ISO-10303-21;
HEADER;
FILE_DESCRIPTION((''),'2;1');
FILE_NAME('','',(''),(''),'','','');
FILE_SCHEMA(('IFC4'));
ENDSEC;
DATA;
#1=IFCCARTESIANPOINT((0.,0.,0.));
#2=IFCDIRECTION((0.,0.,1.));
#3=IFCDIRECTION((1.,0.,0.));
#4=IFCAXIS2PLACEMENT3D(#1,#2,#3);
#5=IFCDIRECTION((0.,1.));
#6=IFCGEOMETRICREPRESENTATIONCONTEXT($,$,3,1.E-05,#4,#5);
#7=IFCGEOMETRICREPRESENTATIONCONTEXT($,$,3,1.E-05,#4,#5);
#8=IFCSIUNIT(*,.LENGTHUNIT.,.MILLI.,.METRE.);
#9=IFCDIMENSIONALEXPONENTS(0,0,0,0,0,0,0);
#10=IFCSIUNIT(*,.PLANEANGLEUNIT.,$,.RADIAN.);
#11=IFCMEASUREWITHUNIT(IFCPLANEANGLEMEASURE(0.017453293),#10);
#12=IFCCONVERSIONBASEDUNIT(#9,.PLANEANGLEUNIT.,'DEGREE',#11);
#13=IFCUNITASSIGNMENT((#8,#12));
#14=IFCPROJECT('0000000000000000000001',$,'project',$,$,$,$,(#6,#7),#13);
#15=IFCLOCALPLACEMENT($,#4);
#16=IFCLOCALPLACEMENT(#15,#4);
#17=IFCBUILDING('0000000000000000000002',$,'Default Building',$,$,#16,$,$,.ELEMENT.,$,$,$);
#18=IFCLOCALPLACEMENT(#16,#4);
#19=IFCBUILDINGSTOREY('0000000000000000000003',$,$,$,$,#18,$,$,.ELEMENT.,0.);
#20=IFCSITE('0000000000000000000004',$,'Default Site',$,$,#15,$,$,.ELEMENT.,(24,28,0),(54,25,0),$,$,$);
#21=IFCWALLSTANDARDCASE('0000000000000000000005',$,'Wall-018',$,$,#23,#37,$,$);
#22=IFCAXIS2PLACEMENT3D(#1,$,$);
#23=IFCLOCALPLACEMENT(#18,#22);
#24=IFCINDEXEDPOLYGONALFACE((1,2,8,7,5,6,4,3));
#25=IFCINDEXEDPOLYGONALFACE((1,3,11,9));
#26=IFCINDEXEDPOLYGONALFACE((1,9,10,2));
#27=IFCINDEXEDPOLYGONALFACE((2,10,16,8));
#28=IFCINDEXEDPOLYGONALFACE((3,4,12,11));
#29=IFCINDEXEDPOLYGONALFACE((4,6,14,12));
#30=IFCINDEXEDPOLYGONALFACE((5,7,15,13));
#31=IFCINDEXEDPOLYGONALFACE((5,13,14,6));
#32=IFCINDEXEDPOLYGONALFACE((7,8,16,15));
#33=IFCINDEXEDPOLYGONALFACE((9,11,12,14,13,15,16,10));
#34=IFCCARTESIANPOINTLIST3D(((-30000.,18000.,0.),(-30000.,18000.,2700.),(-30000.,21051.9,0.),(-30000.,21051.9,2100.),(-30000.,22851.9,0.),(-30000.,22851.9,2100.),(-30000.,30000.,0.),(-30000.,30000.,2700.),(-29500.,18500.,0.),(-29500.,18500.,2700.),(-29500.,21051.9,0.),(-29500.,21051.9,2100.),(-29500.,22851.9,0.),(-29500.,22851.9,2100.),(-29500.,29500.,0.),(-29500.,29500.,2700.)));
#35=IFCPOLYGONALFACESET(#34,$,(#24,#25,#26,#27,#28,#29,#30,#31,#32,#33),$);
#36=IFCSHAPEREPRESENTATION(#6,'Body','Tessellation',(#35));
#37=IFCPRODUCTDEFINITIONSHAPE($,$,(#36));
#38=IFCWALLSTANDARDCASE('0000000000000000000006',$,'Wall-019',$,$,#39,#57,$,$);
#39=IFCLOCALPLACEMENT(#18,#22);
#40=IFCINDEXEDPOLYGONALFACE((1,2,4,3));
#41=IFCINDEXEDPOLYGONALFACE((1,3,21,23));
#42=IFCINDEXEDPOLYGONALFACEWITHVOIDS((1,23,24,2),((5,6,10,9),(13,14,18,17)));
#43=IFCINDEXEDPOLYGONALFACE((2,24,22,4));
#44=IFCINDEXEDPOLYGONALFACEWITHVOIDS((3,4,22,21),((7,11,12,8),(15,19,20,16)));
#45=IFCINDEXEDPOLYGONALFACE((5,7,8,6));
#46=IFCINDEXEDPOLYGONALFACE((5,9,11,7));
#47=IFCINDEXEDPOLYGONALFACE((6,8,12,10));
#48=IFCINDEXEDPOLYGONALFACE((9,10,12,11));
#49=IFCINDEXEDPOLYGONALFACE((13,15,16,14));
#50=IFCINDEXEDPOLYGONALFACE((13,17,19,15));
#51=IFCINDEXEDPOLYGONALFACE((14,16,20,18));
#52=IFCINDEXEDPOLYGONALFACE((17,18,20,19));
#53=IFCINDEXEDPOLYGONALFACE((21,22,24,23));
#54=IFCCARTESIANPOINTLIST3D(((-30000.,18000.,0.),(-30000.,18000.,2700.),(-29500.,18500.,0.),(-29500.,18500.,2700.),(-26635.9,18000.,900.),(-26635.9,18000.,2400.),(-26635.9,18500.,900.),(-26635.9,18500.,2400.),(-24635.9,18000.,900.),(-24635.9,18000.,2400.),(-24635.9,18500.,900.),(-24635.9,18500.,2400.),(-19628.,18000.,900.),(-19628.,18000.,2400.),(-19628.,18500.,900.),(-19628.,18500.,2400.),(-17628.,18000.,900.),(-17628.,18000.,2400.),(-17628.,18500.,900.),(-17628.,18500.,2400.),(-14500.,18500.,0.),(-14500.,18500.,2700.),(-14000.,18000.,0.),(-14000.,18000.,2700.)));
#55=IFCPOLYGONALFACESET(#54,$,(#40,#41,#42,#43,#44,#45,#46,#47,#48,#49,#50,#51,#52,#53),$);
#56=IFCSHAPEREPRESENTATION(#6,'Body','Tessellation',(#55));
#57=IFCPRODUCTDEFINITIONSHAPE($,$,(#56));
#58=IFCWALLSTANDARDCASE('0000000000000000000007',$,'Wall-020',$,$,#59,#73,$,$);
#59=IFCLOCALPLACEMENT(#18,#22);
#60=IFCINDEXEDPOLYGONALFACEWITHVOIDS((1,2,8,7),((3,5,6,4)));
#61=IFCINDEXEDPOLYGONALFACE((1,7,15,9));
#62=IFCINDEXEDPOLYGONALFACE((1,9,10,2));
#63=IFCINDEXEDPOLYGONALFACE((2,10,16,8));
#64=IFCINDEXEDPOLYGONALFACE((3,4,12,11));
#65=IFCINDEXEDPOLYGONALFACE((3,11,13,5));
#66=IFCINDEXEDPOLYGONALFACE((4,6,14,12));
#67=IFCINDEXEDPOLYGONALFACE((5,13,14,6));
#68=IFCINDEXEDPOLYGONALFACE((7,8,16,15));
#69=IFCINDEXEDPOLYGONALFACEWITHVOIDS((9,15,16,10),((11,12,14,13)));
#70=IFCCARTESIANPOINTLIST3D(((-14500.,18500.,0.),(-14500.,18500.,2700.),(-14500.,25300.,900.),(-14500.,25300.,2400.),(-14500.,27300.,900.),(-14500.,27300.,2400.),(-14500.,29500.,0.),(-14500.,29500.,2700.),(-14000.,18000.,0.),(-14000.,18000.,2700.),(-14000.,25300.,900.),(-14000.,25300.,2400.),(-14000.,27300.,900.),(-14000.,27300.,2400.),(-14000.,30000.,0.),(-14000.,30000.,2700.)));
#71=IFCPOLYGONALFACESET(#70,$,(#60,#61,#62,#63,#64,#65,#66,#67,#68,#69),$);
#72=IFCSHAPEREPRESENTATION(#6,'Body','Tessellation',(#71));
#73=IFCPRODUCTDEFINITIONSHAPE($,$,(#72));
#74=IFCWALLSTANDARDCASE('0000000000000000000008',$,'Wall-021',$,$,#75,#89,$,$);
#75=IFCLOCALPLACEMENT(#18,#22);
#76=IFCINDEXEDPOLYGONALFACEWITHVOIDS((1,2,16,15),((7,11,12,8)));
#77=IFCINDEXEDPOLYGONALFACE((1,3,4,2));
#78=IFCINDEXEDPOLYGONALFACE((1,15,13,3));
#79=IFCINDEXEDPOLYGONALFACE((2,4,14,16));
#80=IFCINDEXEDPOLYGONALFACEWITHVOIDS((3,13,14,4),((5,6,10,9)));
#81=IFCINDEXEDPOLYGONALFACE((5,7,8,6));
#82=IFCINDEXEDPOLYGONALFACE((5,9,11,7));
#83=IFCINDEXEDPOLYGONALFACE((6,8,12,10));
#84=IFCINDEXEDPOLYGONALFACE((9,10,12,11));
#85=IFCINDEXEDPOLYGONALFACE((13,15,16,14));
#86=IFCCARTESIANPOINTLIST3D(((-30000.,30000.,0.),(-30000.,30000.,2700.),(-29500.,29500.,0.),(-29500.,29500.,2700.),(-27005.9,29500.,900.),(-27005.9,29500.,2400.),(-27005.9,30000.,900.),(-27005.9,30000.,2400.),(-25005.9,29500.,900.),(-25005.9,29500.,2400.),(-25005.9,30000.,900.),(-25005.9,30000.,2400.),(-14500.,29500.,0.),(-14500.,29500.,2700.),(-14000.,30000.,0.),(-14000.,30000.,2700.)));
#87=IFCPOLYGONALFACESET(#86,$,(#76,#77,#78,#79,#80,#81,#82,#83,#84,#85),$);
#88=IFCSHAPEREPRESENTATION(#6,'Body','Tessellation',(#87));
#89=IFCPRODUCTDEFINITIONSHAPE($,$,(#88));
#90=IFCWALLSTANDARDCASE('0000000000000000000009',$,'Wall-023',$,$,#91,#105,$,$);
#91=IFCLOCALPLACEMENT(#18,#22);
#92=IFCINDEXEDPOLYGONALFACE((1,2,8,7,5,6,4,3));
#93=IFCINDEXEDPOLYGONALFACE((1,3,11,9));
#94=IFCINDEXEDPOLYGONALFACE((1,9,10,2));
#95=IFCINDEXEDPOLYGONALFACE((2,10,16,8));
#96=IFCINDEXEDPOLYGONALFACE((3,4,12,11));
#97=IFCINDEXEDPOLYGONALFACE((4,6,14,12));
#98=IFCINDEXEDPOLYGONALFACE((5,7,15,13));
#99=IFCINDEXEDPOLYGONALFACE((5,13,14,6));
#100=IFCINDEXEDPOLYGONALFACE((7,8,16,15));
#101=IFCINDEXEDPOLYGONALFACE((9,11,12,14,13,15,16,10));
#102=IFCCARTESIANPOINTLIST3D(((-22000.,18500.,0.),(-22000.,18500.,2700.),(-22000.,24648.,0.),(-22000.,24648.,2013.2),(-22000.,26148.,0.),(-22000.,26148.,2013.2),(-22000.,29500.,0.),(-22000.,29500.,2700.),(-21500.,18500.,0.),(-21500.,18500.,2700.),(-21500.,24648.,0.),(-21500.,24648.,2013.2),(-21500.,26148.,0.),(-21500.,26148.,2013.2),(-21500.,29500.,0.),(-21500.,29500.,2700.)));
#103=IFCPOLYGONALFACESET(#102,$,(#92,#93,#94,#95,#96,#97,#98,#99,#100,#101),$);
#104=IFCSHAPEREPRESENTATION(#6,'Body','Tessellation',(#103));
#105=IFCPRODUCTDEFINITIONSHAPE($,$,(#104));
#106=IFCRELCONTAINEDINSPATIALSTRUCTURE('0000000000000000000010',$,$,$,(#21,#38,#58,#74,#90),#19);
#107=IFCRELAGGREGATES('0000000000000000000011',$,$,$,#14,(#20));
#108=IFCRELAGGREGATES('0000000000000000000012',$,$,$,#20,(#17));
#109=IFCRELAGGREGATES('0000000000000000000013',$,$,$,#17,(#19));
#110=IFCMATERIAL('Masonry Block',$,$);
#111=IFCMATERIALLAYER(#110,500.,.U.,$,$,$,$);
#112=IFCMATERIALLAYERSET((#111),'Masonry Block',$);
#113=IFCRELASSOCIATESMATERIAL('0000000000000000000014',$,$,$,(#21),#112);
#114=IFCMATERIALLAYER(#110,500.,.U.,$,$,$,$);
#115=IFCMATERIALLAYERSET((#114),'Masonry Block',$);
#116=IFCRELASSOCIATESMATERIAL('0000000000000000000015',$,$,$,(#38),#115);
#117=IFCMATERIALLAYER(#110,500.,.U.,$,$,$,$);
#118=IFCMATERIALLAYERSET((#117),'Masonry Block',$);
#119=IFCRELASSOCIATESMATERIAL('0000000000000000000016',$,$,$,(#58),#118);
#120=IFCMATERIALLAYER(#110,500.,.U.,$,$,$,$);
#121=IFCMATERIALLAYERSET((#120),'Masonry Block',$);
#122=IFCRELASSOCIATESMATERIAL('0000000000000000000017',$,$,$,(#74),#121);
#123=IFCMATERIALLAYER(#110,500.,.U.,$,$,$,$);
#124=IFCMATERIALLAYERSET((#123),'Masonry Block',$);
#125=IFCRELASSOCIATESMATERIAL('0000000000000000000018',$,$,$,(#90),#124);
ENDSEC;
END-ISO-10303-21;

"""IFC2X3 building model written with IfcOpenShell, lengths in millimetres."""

from ifc_helpers import new_model, entity, si_unit, converted_unit, direction, frame, frame_2d, origin_with_axes, place, context, project, spatial, polyline, rectangle, outline, extrude, material, layer, layer_set, layer_usage, element, save


model = new_model("IFC2X3")

# Units and contexts
context_of_model_1 = context(None, 3, precision=1e-05, world=origin_with_axes(), true_north=direction((0.0, 1.0)))
context_of_model_2 = context(None, 3, precision=1e-05, world=origin_with_axes(), true_north=direction((0.0, 1.0)))
ifc_project = project(units=[si_unit("LENGTHUNIT", "METRE", prefix="MILLI"), converted_unit("PLANEANGLEUNIT", "DEGREE", entity("IfcPlaneAngleMeasure", 0.017453293), si_unit("PLANEANGLEUNIT", "RADIAN"), dimensions=[0, 0, 0, 0, 0, 0, 0])], contexts=[context_of_model_1, context_of_model_2])

# Site, building, storey
site_placement = place(None, origin_with_axes())
site = spatial("IfcSite", under=ifc_project, at=site_placement, Name="Default Site", CompositionType="ELEMENT", RefLatitude=(24, 28, 0), RefLongitude=(54, 25, 0))
building_placement = place(site_placement, origin_with_axes())
building = spatial("IfcBuilding", under=site, at=building_placement, Name="Default Building", CompositionType="ELEMENT")
storey_placement = place(building_placement, origin_with_axes())
storey = spatial("IfcBuildingStorey", under=building, at=storey_placement, CompositionType="ELEMENT", Elevation=0.0)

# Wall, opening
ifc_material = material(Name="Masonry Block")
ifc_layer_1 = layer(ifc_material, 500.0, ventilated="UNKNOWN")
ifc_layer_set_1 = layer_set([ifc_layer_1], Name="Masonry Block")
ifc_layer_usage_1 = layer_usage(ifc_layer_set_1, "AXIS2", "POSITIVE", 0.0)
wall_1_placement = place(storey_placement, frame((-30000.0, 30000.0, 0.0), z_axis=(0.0, 0.0, 1.0), x_axis=(0.0, -1.0, 0.0)))
wall_1 = element("IfcWallStandardCase", 1, at=wall_1_placement, inside=storey, material=ifc_layer_usage_1, Name="Wall-018", context=context_of_model_1, shape_type="SweptSolid", body=[
    extrude(outline(polyline([(0.0, 0.0), (12000.0, 0.0), (11500.0, 500.0), (500.0, 500.0), (0.0, 0.0)])), origin_with_axes(), (0.0, 0.0, 1.0), 2700.0),
])
opening_1_placement = place(wall_1_placement, frame((8048.1, 0.0, 0.0), z_axis=(0.0, 0.0, 1.0), x_axis=(1.0, 0.0, 0.0)))
element("IfcOpeningElement", 2, at=opening_1_placement, cuts=wall_1, context=context_of_model_1, shape_type="SweptSolid", body=[
    extrude(rectangle(XDim=2100.0, YDim=1800.0, at=frame_2d((0.0, 1050.0), x_axis=(0.0, -1.0))), frame((0.0, 0.0, 0.0), z_axis=(0.0, 1.0, 0.0), x_axis=(-1.0, 0.0, 0.0)), (0.0, 0.0, 1.0), 500.0),
])

# Wall, openings
ifc_layer_2 = layer(ifc_material, 500.0, ventilated="UNKNOWN")
ifc_layer_set_2 = layer_set([ifc_layer_2], Name="Masonry Block")
ifc_layer_usage_2 = layer_usage(ifc_layer_set_2, "AXIS2", "POSITIVE", 0.0)
wall_2_placement = place(storey_placement, frame((-30000.0, 18000.0, 0.0), z_axis=(0.0, 0.0, 1.0), x_axis=(1.0, 0.0, 0.0)))
wall_2 = element("IfcWallStandardCase", 3, at=wall_2_placement, inside=storey, material=ifc_layer_usage_2, Name="Wall-019", context=context_of_model_1, shape_type="SweptSolid", body=[
    extrude(outline(polyline([(0.0, 0.0), (16000.0, 0.0), (15500.0, 500.0), (500.0, 500.0), (0.0, 0.0)])), origin_with_axes(), (0.0, 0.0, 1.0), 2700.0),
])
opening_2_placement = place(wall_2_placement, frame((11372.0, 0.0, 900.0), z_axis=(0.0, 0.0, 1.0), x_axis=(1.0, 0.0, 0.0)))
element("IfcOpeningElement", 4, at=opening_2_placement, cuts=wall_2, context=context_of_model_1, shape_type="SweptSolid", body=[
    extrude(rectangle(XDim=1500.0, YDim=2000.0, at=frame_2d((0.0, 750.0), x_axis=(0.0, 1.0))), frame((0.0, 0.0, 0.0), z_axis=(0.0, 1.0, 0.0), x_axis=(-1.0, 0.0, 0.0)), (0.0, 0.0, 1.0), 500.0),
])
opening_3_placement = place(wall_2_placement, frame((4364.1, 0.0, 900.0), z_axis=(0.0, 0.0, 1.0), x_axis=(1.0, 0.0, 0.0)))
element("IfcOpeningElement", 5, at=opening_3_placement, cuts=wall_2, context=context_of_model_1, shape_type="SweptSolid", body=[
    extrude(rectangle(XDim=1500.0, YDim=2000.0, at=frame_2d((0.0, 750.0), x_axis=(0.0, 1.0))), frame((0.0, 0.0, 0.0), z_axis=(0.0, 1.0, 0.0), x_axis=(-1.0, 0.0, 0.0)), (0.0, 0.0, 1.0), 500.0),
])

# Walls, openings
ifc_layer_3 = layer(ifc_material, 500.0, ventilated="UNKNOWN")
ifc_layer_set_3 = layer_set([ifc_layer_3], Name="Masonry Block")
ifc_layer_usage_3 = layer_usage(ifc_layer_set_3, "AXIS2", "POSITIVE", 0.0)
wall_3_placement = place(storey_placement, frame((-14000.0, 18000.0, 0.0), z_axis=(0.0, 0.0, 1.0), x_axis=(0.0, 1.0, 0.0)))
wall_3 = element("IfcWallStandardCase", 6, at=wall_3_placement, inside=storey, material=ifc_layer_usage_3, Name="Wall-020", context=context_of_model_1, shape_type="SweptSolid", body=[
    extrude(outline(polyline([(0.0, 0.0), (12000.0, 0.0), (11500.0, 500.0), (500.0, 500.0), (0.0, 0.0)])), origin_with_axes(), (0.0, 0.0, 1.0), 2700.0),
])
opening_4_placement = place(wall_3_placement, frame((8300.0, 0.0, 900.0), z_axis=(0.0, 0.0, 1.0), x_axis=(1.0, 0.0, 0.0)))
element("IfcOpeningElement", 7, at=opening_4_placement, cuts=wall_3, context=context_of_model_1, shape_type="SweptSolid", body=[
    extrude(rectangle(XDim=1500.0, YDim=2000.0, at=frame_2d((0.0, 750.0), x_axis=(0.0, 1.0))), frame((0.0, 0.0, 0.0), z_axis=(0.0, 1.0, 0.0), x_axis=(-1.0, 0.0, 0.0)), (0.0, 0.0, 1.0), 500.0),
])
ifc_layer_4 = layer(ifc_material, 500.0, ventilated="UNKNOWN")
ifc_layer_set_4 = layer_set([ifc_layer_4], Name="Masonry Block")
ifc_layer_usage_4 = layer_usage(ifc_layer_set_4, "AXIS2", "POSITIVE", 0.0)
wall_4_placement = place(storey_placement, frame((-14000.0, 30000.0, 0.0), z_axis=(0.0, 0.0, 1.0), x_axis=(-1.0, 0.0, 0.0)))
wall_4 = element("IfcWallStandardCase", 8, at=wall_4_placement, inside=storey, material=ifc_layer_usage_4, Name="Wall-021", context=context_of_model_1, shape_type="SweptSolid", body=[
    extrude(outline(polyline([(0.0, 0.0), (16000.0, 0.0), (15500.0, 500.0), (500.0, 500.0), (0.0, 0.0)])), origin_with_axes(), (0.0, 0.0, 1.0), 2700.0),
])
opening_5_placement = place(wall_4_placement, frame((12005.9, 0.0, 900.0), z_axis=(0.0, 0.0, 1.0), x_axis=(1.0, 0.0, 0.0)))
element("IfcOpeningElement", 9, at=opening_5_placement, cuts=wall_4, context=context_of_model_1, shape_type="SweptSolid", body=[
    extrude(rectangle(XDim=1500.0, YDim=2000.0, at=frame_2d((0.0, 750.0), x_axis=(0.0, 1.0))), frame((0.0, 0.0, 0.0), z_axis=(0.0, 1.0, 0.0), x_axis=(-1.0, 0.0, 0.0)), (0.0, 0.0, 1.0), 500.0),
])
ifc_layer_5 = layer(ifc_material, 500.0, ventilated="UNKNOWN")
ifc_layer_set_5 = layer_set([ifc_layer_5], Name="Masonry Block")
ifc_layer_usage_5 = layer_usage(ifc_layer_set_5, "AXIS2", "POSITIVE", 0.0)
wall_5_placement = place(storey_placement, frame((-22000.0, 29500.0, 0.0), z_axis=(0.0, 0.0, 1.0), x_axis=(0.0, -1.0, 0.0)))
wall_5 = element("IfcWallStandardCase", 10, at=wall_5_placement, inside=storey, material=ifc_layer_usage_5, Name="Wall-023", context=context_of_model_1, shape_type="SweptSolid", body=[
    extrude(outline(polyline([(0.0, 0.0), (11000.0, 0.0), (11000.0, 500.0), (0.0, 500.0), (0.0, 0.0)])), origin_with_axes(), (0.0, 0.0, 1.0), 2700.0),
])
opening_6_placement = place(wall_5_placement, frame((4102.0, 0.0, 0.0), z_axis=(0.0, 0.0, 1.0), x_axis=(1.0, 0.0, 0.0)))
element("IfcOpeningElement", 11, at=opening_6_placement, cuts=wall_5, context=context_of_model_1, shape_type="SweptSolid", body=[
    extrude(rectangle(XDim=2013.2, YDim=1500.0, at=frame_2d((0.0, 1006.6), x_axis=(0.0, -1.0))), frame((0.0, 0.0, 0.0), z_axis=(0.0, 1.0, 0.0), x_axis=(-1.0, 0.0, 0.0)), (0.0, 0.0, 1.0), 500.0),
])

save(model, "model.ifc")
